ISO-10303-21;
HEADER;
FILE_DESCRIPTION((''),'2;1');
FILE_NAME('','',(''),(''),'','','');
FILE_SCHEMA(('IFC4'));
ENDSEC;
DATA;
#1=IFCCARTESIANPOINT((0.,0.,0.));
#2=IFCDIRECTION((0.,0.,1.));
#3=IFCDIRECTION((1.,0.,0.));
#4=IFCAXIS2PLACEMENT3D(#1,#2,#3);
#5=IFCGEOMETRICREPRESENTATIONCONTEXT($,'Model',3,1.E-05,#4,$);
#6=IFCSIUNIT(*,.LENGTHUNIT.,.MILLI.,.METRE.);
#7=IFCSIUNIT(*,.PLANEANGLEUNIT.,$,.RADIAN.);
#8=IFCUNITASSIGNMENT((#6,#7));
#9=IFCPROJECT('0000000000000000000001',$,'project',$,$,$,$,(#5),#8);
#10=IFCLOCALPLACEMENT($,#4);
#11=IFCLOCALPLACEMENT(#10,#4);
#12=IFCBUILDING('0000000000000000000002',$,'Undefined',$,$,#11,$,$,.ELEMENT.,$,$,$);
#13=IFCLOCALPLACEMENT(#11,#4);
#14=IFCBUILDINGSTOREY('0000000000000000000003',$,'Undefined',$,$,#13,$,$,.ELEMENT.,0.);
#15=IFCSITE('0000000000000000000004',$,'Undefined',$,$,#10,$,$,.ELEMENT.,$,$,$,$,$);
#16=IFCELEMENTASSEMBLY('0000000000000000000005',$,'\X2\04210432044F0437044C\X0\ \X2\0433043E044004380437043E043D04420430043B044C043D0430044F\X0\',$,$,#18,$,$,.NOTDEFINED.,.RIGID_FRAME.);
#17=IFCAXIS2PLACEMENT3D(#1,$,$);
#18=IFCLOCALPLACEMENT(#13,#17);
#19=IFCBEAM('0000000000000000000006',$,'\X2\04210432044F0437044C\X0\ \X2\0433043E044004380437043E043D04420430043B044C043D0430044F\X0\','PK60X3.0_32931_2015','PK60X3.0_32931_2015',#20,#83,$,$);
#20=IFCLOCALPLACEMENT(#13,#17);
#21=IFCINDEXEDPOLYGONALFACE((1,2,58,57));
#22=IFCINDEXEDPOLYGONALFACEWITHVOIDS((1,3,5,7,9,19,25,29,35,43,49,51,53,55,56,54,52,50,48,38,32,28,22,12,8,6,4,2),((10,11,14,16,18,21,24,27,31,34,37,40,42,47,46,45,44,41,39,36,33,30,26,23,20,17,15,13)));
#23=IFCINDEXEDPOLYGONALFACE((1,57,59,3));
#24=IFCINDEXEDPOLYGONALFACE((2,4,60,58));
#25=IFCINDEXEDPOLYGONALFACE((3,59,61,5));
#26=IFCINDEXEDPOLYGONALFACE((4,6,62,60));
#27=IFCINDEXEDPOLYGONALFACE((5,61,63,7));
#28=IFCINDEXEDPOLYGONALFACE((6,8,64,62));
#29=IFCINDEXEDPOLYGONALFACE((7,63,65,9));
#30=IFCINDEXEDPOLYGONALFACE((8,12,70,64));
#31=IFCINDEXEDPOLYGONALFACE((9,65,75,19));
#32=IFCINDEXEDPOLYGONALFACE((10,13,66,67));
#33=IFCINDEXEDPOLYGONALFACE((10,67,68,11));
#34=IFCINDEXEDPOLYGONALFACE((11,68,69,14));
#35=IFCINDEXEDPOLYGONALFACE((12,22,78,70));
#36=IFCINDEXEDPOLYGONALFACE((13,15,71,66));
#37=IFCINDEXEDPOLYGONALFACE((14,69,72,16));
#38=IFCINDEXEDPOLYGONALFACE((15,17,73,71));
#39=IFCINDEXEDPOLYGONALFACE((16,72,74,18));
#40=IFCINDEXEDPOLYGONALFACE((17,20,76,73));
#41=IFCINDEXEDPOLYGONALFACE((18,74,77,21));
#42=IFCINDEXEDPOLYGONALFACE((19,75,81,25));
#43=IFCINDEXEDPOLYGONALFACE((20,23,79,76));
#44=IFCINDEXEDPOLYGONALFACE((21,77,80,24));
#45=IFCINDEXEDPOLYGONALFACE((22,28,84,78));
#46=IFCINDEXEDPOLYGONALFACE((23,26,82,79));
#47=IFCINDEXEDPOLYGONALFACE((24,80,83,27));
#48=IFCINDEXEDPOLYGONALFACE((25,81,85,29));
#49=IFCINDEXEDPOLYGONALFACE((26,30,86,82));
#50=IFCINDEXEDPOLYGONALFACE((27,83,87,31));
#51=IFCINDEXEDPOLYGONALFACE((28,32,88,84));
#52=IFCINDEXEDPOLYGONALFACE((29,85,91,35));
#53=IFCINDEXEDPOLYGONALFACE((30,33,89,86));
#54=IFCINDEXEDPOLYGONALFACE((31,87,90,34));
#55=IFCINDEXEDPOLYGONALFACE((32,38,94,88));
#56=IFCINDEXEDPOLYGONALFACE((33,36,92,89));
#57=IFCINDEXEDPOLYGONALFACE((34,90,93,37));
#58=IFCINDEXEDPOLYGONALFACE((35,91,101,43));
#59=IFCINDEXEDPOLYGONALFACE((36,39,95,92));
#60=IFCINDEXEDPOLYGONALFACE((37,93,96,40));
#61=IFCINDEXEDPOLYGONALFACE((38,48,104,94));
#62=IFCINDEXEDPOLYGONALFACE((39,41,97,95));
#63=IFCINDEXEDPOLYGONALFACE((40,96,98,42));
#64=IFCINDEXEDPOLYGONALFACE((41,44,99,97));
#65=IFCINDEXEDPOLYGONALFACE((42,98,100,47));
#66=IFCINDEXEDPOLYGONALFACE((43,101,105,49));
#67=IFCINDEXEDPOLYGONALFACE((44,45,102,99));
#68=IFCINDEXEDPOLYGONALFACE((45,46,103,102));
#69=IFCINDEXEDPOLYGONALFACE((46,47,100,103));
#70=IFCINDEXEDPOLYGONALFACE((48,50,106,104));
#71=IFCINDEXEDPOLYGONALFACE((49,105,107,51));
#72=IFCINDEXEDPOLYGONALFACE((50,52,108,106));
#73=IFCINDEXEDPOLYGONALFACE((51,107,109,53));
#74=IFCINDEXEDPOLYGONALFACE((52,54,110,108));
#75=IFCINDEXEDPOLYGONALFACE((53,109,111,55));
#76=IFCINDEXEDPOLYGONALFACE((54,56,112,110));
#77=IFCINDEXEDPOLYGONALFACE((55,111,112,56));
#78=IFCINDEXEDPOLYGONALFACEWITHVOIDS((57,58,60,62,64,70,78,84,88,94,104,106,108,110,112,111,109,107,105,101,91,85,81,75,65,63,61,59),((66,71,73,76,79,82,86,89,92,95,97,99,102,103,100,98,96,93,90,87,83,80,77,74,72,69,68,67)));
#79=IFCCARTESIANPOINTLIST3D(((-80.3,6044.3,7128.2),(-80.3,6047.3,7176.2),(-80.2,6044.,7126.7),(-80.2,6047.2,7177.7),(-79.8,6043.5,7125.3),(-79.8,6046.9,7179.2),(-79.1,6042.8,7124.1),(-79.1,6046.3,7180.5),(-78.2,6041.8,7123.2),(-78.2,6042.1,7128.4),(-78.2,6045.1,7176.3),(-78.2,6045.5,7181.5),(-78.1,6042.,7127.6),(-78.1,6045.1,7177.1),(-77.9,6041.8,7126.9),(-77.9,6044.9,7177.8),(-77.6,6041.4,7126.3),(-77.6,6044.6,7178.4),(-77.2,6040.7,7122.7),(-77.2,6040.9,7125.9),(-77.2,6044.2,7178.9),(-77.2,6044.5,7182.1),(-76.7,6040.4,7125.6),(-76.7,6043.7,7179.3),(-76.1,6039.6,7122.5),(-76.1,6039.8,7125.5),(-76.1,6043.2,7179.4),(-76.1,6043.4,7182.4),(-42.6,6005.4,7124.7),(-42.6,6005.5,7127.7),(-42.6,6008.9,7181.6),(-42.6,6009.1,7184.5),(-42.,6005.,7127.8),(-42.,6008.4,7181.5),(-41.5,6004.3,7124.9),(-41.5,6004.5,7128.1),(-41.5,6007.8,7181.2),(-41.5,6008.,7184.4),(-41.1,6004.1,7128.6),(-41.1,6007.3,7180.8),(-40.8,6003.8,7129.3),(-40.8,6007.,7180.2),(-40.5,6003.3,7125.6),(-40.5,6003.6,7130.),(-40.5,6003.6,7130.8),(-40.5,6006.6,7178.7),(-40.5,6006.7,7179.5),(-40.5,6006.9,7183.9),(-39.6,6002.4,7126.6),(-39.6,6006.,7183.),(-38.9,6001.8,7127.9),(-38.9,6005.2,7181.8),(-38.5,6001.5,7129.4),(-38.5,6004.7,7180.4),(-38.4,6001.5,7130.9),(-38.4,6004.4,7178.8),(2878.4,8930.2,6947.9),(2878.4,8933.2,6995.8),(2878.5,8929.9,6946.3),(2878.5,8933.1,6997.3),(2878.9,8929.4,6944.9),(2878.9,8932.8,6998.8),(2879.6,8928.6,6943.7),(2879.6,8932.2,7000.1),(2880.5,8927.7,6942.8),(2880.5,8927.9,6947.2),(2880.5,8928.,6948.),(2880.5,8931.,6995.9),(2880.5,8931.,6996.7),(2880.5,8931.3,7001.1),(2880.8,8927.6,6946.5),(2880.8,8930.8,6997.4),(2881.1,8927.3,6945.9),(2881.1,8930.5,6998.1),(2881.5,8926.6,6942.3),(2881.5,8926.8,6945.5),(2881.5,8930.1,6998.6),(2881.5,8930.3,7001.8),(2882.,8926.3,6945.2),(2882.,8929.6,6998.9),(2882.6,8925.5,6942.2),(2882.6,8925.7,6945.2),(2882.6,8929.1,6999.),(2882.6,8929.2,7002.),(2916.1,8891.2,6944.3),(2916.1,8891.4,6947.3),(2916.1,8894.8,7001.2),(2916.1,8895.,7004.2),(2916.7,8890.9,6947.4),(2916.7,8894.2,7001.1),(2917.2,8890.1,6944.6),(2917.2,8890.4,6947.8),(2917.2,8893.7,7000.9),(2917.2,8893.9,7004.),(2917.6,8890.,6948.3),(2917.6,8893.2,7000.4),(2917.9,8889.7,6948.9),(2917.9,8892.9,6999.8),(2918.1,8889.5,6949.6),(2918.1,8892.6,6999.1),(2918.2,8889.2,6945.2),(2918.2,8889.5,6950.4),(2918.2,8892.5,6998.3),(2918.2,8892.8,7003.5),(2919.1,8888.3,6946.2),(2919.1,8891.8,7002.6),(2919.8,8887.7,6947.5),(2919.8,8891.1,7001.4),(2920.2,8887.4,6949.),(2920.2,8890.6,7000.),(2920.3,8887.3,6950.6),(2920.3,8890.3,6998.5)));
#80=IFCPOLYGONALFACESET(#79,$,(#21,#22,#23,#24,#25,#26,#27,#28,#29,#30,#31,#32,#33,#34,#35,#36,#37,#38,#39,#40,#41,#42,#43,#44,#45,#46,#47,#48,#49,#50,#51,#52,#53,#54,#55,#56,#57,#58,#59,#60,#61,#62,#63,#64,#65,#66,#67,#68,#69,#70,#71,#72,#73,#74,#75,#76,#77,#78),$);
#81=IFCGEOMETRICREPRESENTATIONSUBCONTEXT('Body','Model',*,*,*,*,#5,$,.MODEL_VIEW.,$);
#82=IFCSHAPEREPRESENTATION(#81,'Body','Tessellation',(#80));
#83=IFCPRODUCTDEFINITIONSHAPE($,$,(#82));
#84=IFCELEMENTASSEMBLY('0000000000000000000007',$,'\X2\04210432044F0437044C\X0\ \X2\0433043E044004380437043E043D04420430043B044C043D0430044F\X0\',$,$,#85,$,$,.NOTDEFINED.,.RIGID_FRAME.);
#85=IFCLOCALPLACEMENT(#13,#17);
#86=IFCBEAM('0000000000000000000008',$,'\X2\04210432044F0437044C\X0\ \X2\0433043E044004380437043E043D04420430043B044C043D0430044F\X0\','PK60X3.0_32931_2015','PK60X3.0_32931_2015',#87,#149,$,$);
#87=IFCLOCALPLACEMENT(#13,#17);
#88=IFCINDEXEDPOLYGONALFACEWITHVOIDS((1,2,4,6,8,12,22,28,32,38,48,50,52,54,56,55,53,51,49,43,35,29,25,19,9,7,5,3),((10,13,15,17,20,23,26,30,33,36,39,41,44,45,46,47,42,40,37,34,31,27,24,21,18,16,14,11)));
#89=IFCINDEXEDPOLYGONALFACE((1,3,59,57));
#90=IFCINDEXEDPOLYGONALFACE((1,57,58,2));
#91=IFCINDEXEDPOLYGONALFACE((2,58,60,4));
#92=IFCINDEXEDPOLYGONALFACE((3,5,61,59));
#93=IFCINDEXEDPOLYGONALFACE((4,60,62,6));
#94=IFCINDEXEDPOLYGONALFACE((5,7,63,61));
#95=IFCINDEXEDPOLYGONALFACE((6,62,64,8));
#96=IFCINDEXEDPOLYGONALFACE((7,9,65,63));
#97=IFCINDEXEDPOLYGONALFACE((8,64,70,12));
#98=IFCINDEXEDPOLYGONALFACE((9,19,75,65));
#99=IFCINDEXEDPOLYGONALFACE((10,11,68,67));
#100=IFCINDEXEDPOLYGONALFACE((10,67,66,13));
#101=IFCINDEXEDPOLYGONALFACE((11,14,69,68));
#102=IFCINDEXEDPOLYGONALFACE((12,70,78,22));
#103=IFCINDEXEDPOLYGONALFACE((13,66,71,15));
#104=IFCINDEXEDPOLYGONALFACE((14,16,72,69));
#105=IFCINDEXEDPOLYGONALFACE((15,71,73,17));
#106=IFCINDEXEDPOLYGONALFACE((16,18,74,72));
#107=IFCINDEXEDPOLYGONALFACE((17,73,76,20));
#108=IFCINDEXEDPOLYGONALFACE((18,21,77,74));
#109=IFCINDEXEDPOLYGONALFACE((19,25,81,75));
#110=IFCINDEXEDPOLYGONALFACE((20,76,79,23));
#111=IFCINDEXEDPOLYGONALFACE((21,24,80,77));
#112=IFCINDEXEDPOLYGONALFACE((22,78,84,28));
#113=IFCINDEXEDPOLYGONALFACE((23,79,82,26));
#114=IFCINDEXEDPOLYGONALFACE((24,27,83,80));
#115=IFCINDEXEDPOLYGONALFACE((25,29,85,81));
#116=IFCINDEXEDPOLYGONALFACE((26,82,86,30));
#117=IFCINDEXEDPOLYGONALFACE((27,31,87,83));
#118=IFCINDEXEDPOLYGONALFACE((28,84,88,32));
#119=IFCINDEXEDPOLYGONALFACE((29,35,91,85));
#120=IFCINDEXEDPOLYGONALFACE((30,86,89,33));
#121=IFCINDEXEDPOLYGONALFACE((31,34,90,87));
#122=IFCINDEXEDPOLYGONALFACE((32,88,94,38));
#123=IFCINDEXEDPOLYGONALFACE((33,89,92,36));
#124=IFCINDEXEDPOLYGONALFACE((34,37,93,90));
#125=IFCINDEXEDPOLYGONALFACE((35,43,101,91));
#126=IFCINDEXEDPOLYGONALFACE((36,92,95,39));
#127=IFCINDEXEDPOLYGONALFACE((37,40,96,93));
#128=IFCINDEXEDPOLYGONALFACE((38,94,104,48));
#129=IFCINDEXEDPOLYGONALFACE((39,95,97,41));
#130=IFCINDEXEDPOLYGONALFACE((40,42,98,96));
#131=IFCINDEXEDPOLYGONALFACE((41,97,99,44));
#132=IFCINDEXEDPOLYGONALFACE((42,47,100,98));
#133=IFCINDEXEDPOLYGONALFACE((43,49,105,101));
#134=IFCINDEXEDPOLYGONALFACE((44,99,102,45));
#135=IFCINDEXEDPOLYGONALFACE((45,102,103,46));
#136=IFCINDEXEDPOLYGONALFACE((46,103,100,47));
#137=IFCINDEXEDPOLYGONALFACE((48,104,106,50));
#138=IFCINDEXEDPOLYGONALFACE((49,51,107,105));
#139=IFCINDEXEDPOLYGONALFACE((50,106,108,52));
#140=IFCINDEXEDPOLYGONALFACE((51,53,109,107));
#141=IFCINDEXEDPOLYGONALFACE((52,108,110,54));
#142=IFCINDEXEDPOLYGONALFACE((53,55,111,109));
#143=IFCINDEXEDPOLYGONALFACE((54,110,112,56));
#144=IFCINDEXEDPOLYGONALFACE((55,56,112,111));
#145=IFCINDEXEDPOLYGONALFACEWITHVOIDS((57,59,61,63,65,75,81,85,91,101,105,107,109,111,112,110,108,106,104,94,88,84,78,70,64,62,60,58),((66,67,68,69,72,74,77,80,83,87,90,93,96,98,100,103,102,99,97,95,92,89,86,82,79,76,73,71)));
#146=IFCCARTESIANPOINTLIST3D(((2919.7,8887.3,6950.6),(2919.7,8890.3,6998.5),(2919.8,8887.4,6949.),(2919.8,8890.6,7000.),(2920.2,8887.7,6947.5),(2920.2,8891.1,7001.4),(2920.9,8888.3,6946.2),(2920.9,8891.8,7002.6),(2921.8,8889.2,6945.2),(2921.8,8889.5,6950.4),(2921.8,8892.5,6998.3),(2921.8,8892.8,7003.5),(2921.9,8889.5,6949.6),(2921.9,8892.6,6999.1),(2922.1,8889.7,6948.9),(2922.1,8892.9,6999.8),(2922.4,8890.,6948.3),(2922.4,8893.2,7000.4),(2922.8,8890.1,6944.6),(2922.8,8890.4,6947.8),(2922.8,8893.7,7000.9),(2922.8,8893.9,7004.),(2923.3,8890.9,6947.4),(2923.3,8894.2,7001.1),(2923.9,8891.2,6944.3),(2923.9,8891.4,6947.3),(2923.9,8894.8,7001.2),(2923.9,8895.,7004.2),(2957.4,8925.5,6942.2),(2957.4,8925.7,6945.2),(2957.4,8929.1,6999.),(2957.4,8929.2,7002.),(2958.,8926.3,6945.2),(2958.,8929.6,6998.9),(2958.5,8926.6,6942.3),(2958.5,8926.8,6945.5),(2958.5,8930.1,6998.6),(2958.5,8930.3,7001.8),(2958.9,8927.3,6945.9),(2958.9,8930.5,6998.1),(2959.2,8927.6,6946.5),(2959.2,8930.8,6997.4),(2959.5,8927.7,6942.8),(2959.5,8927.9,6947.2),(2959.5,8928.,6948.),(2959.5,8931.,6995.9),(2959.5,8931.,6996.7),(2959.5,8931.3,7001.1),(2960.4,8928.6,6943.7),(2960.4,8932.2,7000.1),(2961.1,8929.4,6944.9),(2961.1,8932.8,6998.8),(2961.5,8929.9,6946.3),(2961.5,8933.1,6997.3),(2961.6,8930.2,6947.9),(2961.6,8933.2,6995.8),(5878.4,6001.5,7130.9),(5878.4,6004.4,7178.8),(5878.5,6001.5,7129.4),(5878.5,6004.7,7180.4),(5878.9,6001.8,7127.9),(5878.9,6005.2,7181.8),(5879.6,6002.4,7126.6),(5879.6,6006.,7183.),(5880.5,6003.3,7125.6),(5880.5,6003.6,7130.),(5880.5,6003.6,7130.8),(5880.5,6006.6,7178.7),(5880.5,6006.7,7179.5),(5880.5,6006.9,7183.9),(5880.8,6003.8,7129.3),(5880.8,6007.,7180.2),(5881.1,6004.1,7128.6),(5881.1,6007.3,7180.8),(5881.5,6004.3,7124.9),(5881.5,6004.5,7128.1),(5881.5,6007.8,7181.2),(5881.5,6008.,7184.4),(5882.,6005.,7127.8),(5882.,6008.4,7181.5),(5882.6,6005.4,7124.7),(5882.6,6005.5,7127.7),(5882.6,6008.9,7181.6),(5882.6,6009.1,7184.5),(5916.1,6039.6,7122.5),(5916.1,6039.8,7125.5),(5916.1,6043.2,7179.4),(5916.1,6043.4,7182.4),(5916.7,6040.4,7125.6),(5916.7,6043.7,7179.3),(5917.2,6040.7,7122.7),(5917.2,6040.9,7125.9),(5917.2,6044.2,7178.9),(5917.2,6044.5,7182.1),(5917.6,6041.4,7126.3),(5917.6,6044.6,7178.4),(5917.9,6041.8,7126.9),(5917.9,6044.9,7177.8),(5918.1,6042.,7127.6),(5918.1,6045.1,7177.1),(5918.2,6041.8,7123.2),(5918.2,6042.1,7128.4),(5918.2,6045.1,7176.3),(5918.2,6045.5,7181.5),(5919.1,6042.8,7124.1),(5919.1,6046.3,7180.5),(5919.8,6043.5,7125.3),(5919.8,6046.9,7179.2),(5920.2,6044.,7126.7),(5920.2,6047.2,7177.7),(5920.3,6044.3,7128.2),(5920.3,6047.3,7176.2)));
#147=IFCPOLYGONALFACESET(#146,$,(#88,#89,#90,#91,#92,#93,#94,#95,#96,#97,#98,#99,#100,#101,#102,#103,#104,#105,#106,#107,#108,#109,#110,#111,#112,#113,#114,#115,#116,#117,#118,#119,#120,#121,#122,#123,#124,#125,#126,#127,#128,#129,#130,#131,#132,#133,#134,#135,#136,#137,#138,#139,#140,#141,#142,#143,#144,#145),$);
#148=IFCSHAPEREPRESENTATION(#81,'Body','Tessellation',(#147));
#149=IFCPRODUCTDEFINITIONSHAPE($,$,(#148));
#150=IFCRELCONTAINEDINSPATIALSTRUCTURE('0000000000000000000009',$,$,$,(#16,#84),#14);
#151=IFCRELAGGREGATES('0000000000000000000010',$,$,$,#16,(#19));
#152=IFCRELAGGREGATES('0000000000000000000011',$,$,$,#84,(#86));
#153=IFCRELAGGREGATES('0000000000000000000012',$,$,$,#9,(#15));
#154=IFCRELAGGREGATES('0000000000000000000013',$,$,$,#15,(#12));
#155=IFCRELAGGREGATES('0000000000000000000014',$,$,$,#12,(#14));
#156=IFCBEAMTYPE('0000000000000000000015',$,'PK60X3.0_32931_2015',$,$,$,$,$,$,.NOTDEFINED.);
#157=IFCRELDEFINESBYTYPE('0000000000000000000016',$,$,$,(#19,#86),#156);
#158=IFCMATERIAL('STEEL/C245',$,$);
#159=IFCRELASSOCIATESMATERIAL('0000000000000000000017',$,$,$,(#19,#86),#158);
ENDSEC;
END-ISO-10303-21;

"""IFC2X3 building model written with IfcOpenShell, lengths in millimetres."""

from ifc_helpers import new_model, si_unit, frame, origin_with_axes, origin_2d_with_axis, place, context, subcontext, project, spatial, hollow_rectangle, extrude, material, type_object, element, aggregate, save


model = new_model("IFC2X3")

# Units and contexts
model_context = context("Model", 3, precision=1e-05, world=origin_with_axes())
body_context = subcontext(model_context, "Body", "Model", "MODEL_VIEW")
ifc_project = project(units=[si_unit("LENGTHUNIT", "METRE", prefix="MILLI"), si_unit("PLANEANGLEUNIT", "RADIAN")], contexts=[model_context])

# Site, building, storey
site_placement = place(None, origin_with_axes())
site = spatial("IfcSite", under=ifc_project, at=site_placement, Name="Undefined", CompositionType="ELEMENT")
building_placement = place(site_placement, origin_with_axes())
building = spatial("IfcBuilding", under=site, at=building_placement, Name="Undefined", CompositionType="ELEMENT")
storey_placement = place(building_placement, origin_with_axes())
storey = spatial("IfcBuildingStorey", under=building, at=storey_placement, Name="Undefined", CompositionType="ELEMENT", Elevation=0.0)

# Shared definitions
ifc_material = material(Name="STEEL/C245")

# Element assemblies, beams
beam_type_1 = type_object("IfcBeamType", Name="PK60X3.0_32931_2015", PredefinedType="NOTDEFINED")
assembly_1_placement = place(storey_placement, origin_with_axes())
assembly_1 = element("IfcElementAssembly", 1, at=assembly_1_placement, inside=storey, Name="Связь горизонтальная", AssemblyPlace="NOTDEFINED", PredefinedType="RIGID_FRAME")
beam_1_placement = place(assembly_1_placement, frame((-59.3, 6024.4, 7153.5), z_axis=(0.0, 0.062378, 0.998053), x_axis=(0.715179, 0.69758, -0.043599)))
beam_1 = element("IfcBeam", 2, at=beam_1_placement, type_object=beam_type_1, material=ifc_material, Name="Связь горизонтальная", Description="PK60X3.0_32931_2015", ObjectType="PK60X3.0_32931_2015", context=body_context, shape_type="SweptSolid", body=[
    extrude(hollow_rectangle(XDim=60.0, YDim=60.0, WallThickness=3.0, InnerFilletRadius=3.0, OuterFilletRadius=6.0, at=origin_2d_with_axis()), frame((4137.0, 0.0, 0.0), z_axis=(-1.0, 0.0, 0.0), x_axis=(0.0, -1.0, 0.0)), (0.0, 0.0, 1.0), 4137.0),
])
aggregate(assembly_1, [beam_1])
assembly_2_placement = place(storey_placement, origin_with_axes())
assembly_2 = element("IfcElementAssembly", 3, at=assembly_2_placement, inside=storey, Name="Связь горизонтальная", AssemblyPlace="NOTDEFINED", PredefinedType="RIGID_FRAME")
beam_2_placement = place(assembly_2_placement, frame((5899.3, 6024.4, 7153.5), z_axis=(0.0, 0.062378, 0.998053), x_axis=(-0.715179, 0.69758, -0.043599)))
beam_2 = element("IfcBeam", 4, at=beam_2_placement, type_object=beam_type_1, material=ifc_material, Name="Связь горизонтальная", Description="PK60X3.0_32931_2015", ObjectType="PK60X3.0_32931_2015", context=body_context, shape_type="SweptSolid", body=[
    extrude(hollow_rectangle(XDim=60.0, YDim=60.0, WallThickness=3.0, InnerFilletRadius=3.0, OuterFilletRadius=6.0, at=origin_2d_with_axis()), frame((4137.0, 0.0, 0.0), z_axis=(-1.0, 0.0, 0.0), x_axis=(0.0, -1.0, 0.0)), (0.0, 0.0, 1.0), 4137.0),
])
aggregate(assembly_2, [beam_2])

save(model, "model.ifc")
